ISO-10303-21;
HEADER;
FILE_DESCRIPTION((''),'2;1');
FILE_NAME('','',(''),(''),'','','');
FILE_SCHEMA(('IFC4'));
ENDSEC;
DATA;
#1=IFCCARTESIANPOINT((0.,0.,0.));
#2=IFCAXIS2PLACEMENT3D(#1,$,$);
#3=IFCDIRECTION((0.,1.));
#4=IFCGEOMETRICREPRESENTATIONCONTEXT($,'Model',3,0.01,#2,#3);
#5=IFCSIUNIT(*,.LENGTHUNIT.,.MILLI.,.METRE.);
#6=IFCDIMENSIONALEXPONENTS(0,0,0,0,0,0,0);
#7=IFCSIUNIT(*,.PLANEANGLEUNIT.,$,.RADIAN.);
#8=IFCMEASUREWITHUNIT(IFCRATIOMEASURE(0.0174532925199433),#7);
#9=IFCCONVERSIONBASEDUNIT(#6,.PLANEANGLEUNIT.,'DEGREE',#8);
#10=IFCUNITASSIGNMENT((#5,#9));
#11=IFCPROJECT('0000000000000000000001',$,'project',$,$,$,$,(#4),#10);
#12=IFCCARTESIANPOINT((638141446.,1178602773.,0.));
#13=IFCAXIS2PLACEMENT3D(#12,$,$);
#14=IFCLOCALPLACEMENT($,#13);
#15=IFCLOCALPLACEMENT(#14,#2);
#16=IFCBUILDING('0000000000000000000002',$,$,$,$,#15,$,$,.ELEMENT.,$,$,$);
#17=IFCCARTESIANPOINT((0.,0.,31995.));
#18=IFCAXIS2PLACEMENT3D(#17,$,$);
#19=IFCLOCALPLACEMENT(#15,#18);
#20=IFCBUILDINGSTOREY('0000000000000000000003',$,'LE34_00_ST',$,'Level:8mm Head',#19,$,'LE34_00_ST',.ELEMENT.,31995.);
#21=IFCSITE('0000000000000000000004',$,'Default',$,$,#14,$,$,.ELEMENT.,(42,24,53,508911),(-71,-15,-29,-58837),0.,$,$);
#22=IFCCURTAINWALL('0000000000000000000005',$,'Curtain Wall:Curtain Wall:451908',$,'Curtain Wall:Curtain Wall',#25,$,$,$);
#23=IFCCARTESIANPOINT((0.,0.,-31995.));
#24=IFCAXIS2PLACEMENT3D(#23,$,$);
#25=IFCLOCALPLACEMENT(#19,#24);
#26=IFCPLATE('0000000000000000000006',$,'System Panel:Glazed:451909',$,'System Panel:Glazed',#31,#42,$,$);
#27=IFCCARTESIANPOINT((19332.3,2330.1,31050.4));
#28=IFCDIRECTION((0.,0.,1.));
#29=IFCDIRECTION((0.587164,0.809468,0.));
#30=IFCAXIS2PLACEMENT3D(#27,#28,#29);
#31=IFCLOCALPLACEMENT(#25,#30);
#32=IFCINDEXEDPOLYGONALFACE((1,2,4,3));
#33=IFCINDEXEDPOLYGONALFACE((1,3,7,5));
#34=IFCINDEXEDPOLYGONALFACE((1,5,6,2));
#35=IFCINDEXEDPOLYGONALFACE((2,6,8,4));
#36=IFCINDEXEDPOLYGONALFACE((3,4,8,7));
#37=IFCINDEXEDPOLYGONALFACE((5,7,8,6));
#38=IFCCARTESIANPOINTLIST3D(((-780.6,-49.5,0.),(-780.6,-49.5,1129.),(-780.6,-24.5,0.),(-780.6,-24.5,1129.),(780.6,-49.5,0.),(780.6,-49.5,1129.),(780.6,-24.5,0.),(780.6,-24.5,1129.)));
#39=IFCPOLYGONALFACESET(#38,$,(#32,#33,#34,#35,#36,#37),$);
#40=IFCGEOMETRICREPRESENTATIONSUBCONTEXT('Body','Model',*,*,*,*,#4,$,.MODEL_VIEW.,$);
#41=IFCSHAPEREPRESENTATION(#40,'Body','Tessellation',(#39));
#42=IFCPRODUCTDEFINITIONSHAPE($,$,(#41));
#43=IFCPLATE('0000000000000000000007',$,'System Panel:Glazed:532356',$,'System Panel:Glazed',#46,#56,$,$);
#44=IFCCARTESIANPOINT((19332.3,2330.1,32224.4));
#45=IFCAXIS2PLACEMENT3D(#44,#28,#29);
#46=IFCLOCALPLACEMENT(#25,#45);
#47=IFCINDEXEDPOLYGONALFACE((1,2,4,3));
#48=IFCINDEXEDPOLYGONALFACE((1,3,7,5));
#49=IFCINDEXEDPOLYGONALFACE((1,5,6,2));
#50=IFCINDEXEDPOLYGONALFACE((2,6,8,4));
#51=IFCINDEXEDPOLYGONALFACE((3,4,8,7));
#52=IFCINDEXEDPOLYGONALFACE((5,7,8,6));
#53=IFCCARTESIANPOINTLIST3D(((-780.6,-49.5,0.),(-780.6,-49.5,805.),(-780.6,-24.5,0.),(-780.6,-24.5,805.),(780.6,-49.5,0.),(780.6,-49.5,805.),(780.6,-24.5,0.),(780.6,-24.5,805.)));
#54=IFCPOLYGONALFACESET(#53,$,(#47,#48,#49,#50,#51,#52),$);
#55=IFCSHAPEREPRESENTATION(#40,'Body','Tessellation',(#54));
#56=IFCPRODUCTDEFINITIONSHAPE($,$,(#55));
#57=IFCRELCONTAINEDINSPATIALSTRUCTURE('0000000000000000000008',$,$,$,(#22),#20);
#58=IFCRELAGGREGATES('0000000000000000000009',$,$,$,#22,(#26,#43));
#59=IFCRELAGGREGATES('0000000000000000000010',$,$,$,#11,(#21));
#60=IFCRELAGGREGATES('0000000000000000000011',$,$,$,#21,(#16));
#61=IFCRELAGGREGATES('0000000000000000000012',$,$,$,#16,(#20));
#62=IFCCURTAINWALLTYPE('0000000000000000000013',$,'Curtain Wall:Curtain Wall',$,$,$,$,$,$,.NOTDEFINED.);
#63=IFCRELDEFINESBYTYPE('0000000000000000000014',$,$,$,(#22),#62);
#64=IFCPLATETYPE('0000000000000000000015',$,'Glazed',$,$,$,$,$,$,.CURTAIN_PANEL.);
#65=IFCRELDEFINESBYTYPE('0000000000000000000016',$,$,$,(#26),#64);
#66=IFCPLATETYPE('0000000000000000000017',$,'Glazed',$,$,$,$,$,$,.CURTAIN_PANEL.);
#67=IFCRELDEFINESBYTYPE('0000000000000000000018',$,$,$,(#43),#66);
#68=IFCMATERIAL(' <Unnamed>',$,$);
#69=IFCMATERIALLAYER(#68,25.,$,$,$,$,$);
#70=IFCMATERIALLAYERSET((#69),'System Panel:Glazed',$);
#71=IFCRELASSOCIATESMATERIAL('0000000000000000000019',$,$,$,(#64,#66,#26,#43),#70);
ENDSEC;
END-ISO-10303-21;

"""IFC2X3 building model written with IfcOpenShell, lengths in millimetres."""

from ifc_helpers import new_model, entity, si_unit, converted_unit, direction, frame, frame_2d, origin, place, context, subcontext, project, spatial, rectangle, extrude, source, transform, mapped, material, layer, layer_set, layer_usage, type_object, type_shapes, element, aggregate, save


model = new_model("IFC2X3")

# Units and contexts
model_context = context("Model", 3, precision=0.01, world=origin(), true_north=direction((0.0, 1.0)))
body_context = subcontext(model_context, "Body", "Model", "MODEL_VIEW")
ifc_project = project(units=[si_unit("LENGTHUNIT", "METRE", prefix="MILLI"), converted_unit("PLANEANGLEUNIT", "DEGREE", entity("IfcRatioMeasure", 0.0174532925199433), si_unit("PLANEANGLEUNIT", "RADIAN"), dimensions=[0, 0, 0, 0, 0, 0, 0])], contexts=[model_context])

# Site, building, storey
site_placement = place(None, frame((638141446.0, 1178602773.0, 0.0)))
site = spatial("IfcSite", under=ifc_project, at=site_placement, Name="Default", CompositionType="ELEMENT", RefLatitude=(42, 24, 53, 508911), RefLongitude=(-71, -15, -29, -58837), RefElevation=0.0)
building_placement = place(site_placement, origin())
building = spatial("IfcBuilding", under=site, at=building_placement, CompositionType="ELEMENT")
storey_placement = place(building_placement, frame((0.0, 0.0, 31995.0)))
storey = spatial("IfcBuildingStorey", under=building, at=storey_placement, Name="LE34_00_ST", ObjectType="Level:8mm Head", LongName="LE34_00_ST", CompositionType="ELEMENT", Elevation=31995.0)

# Curtain wall
curtain_wall_type = type_object("IfcCurtainWallType", Name="Curtain Wall:Curtain Wall", PredefinedType="NOTDEFINED")
curtain_wall_1_placement = place(storey_placement, frame((0.0, 0.0, -31995.0)))
curtain_wall_1 = element("IfcCurtainWall", 1, at=curtain_wall_1_placement, inside=storey, type_object=curtain_wall_type, Name="Curtain Wall:Curtain Wall:451908", ObjectType="Curtain Wall:Curtain Wall")

# Plates
ifc_material_1 = material(Name=" <Unnamed>")
ifc_layer_1 = layer(ifc_material_1, 25.0)
ifc_layer_set_1 = layer_set([ifc_layer_1], Name="System Panel:Glazed")
ifc_layer_usage_1 = layer_usage(ifc_layer_set_1, "AXIS3", "POSITIVE", 0.1)
plate_type_1 = type_object("IfcPlateType", Name="Glazed", PredefinedType="CURTAIN_PANEL", material=ifc_layer_set_1)
shared_shape_1 = source(origin(), body_context, "Body", "SweptSolid", [
    extrude(rectangle(XDim=25.0, YDim=1561.3, at=frame_2d((0.0, 0.0), x_axis=(1.0, 0.0))), frame((0.0, -37.0, 0.0), z_axis=(0.0, 0.0, 1.0), x_axis=(0.0, 1.0, 0.0)), (0.0, 0.0, 1.0), 1129.0),
])
type_shapes(plate_type_1, [shared_shape_1])
plate_1_placement = place(curtain_wall_1_placement, frame((19332.3, 2330.1, 31050.4), z_axis=(0.0, 0.0, 1.0), x_axis=(0.587164, 0.809468, 0.0)))
plate_1 = element("IfcPlate", 2, at=plate_1_placement, type_object=plate_type_1, material=ifc_layer_usage_1, Name="System Panel:Glazed:451909", ObjectType="System Panel:Glazed", context=body_context, shape_type="MappedRepresentation", body=[
    mapped(shared_shape_1, transform((0.0, 0.0, 0.0), scale=1.0)),
])
ifc_layer_usage_2 = layer_usage(ifc_layer_set_1, "AXIS3", "POSITIVE", 0.1)
plate_type_2 = type_object("IfcPlateType", Name="Glazed", PredefinedType="CURTAIN_PANEL", material=ifc_layer_set_1)
shared_shape_2 = source(origin(), body_context, "Body", "SweptSolid", [
    extrude(rectangle(XDim=25.0, YDim=1561.3, at=frame_2d((0.0, 0.0), x_axis=(1.0, 0.0))), frame((0.0, -37.0, 0.0), z_axis=(0.0, 0.0, 1.0), x_axis=(0.0, 1.0, 0.0)), (0.0, 0.0, 1.0), 805.0),
])
type_shapes(plate_type_2, [shared_shape_2])
plate_2_placement = place(curtain_wall_1_placement, frame((19332.3, 2330.1, 32224.4), z_axis=(0.0, 0.0, 1.0), x_axis=(0.587164, 0.809468, 0.0)))
plate_2 = element("IfcPlate", 3, at=plate_2_placement, type_object=plate_type_2, material=ifc_layer_usage_2, Name="System Panel:Glazed:532356", ObjectType="System Panel:Glazed", context=body_context, shape_type="MappedRepresentation", body=[
    mapped(shared_shape_2, transform((0.0, 0.0, 0.0), scale=1.0)),
])
aggregate(curtain_wall_1, [plate_1, plate_2])

save(model, "model.ifc")
